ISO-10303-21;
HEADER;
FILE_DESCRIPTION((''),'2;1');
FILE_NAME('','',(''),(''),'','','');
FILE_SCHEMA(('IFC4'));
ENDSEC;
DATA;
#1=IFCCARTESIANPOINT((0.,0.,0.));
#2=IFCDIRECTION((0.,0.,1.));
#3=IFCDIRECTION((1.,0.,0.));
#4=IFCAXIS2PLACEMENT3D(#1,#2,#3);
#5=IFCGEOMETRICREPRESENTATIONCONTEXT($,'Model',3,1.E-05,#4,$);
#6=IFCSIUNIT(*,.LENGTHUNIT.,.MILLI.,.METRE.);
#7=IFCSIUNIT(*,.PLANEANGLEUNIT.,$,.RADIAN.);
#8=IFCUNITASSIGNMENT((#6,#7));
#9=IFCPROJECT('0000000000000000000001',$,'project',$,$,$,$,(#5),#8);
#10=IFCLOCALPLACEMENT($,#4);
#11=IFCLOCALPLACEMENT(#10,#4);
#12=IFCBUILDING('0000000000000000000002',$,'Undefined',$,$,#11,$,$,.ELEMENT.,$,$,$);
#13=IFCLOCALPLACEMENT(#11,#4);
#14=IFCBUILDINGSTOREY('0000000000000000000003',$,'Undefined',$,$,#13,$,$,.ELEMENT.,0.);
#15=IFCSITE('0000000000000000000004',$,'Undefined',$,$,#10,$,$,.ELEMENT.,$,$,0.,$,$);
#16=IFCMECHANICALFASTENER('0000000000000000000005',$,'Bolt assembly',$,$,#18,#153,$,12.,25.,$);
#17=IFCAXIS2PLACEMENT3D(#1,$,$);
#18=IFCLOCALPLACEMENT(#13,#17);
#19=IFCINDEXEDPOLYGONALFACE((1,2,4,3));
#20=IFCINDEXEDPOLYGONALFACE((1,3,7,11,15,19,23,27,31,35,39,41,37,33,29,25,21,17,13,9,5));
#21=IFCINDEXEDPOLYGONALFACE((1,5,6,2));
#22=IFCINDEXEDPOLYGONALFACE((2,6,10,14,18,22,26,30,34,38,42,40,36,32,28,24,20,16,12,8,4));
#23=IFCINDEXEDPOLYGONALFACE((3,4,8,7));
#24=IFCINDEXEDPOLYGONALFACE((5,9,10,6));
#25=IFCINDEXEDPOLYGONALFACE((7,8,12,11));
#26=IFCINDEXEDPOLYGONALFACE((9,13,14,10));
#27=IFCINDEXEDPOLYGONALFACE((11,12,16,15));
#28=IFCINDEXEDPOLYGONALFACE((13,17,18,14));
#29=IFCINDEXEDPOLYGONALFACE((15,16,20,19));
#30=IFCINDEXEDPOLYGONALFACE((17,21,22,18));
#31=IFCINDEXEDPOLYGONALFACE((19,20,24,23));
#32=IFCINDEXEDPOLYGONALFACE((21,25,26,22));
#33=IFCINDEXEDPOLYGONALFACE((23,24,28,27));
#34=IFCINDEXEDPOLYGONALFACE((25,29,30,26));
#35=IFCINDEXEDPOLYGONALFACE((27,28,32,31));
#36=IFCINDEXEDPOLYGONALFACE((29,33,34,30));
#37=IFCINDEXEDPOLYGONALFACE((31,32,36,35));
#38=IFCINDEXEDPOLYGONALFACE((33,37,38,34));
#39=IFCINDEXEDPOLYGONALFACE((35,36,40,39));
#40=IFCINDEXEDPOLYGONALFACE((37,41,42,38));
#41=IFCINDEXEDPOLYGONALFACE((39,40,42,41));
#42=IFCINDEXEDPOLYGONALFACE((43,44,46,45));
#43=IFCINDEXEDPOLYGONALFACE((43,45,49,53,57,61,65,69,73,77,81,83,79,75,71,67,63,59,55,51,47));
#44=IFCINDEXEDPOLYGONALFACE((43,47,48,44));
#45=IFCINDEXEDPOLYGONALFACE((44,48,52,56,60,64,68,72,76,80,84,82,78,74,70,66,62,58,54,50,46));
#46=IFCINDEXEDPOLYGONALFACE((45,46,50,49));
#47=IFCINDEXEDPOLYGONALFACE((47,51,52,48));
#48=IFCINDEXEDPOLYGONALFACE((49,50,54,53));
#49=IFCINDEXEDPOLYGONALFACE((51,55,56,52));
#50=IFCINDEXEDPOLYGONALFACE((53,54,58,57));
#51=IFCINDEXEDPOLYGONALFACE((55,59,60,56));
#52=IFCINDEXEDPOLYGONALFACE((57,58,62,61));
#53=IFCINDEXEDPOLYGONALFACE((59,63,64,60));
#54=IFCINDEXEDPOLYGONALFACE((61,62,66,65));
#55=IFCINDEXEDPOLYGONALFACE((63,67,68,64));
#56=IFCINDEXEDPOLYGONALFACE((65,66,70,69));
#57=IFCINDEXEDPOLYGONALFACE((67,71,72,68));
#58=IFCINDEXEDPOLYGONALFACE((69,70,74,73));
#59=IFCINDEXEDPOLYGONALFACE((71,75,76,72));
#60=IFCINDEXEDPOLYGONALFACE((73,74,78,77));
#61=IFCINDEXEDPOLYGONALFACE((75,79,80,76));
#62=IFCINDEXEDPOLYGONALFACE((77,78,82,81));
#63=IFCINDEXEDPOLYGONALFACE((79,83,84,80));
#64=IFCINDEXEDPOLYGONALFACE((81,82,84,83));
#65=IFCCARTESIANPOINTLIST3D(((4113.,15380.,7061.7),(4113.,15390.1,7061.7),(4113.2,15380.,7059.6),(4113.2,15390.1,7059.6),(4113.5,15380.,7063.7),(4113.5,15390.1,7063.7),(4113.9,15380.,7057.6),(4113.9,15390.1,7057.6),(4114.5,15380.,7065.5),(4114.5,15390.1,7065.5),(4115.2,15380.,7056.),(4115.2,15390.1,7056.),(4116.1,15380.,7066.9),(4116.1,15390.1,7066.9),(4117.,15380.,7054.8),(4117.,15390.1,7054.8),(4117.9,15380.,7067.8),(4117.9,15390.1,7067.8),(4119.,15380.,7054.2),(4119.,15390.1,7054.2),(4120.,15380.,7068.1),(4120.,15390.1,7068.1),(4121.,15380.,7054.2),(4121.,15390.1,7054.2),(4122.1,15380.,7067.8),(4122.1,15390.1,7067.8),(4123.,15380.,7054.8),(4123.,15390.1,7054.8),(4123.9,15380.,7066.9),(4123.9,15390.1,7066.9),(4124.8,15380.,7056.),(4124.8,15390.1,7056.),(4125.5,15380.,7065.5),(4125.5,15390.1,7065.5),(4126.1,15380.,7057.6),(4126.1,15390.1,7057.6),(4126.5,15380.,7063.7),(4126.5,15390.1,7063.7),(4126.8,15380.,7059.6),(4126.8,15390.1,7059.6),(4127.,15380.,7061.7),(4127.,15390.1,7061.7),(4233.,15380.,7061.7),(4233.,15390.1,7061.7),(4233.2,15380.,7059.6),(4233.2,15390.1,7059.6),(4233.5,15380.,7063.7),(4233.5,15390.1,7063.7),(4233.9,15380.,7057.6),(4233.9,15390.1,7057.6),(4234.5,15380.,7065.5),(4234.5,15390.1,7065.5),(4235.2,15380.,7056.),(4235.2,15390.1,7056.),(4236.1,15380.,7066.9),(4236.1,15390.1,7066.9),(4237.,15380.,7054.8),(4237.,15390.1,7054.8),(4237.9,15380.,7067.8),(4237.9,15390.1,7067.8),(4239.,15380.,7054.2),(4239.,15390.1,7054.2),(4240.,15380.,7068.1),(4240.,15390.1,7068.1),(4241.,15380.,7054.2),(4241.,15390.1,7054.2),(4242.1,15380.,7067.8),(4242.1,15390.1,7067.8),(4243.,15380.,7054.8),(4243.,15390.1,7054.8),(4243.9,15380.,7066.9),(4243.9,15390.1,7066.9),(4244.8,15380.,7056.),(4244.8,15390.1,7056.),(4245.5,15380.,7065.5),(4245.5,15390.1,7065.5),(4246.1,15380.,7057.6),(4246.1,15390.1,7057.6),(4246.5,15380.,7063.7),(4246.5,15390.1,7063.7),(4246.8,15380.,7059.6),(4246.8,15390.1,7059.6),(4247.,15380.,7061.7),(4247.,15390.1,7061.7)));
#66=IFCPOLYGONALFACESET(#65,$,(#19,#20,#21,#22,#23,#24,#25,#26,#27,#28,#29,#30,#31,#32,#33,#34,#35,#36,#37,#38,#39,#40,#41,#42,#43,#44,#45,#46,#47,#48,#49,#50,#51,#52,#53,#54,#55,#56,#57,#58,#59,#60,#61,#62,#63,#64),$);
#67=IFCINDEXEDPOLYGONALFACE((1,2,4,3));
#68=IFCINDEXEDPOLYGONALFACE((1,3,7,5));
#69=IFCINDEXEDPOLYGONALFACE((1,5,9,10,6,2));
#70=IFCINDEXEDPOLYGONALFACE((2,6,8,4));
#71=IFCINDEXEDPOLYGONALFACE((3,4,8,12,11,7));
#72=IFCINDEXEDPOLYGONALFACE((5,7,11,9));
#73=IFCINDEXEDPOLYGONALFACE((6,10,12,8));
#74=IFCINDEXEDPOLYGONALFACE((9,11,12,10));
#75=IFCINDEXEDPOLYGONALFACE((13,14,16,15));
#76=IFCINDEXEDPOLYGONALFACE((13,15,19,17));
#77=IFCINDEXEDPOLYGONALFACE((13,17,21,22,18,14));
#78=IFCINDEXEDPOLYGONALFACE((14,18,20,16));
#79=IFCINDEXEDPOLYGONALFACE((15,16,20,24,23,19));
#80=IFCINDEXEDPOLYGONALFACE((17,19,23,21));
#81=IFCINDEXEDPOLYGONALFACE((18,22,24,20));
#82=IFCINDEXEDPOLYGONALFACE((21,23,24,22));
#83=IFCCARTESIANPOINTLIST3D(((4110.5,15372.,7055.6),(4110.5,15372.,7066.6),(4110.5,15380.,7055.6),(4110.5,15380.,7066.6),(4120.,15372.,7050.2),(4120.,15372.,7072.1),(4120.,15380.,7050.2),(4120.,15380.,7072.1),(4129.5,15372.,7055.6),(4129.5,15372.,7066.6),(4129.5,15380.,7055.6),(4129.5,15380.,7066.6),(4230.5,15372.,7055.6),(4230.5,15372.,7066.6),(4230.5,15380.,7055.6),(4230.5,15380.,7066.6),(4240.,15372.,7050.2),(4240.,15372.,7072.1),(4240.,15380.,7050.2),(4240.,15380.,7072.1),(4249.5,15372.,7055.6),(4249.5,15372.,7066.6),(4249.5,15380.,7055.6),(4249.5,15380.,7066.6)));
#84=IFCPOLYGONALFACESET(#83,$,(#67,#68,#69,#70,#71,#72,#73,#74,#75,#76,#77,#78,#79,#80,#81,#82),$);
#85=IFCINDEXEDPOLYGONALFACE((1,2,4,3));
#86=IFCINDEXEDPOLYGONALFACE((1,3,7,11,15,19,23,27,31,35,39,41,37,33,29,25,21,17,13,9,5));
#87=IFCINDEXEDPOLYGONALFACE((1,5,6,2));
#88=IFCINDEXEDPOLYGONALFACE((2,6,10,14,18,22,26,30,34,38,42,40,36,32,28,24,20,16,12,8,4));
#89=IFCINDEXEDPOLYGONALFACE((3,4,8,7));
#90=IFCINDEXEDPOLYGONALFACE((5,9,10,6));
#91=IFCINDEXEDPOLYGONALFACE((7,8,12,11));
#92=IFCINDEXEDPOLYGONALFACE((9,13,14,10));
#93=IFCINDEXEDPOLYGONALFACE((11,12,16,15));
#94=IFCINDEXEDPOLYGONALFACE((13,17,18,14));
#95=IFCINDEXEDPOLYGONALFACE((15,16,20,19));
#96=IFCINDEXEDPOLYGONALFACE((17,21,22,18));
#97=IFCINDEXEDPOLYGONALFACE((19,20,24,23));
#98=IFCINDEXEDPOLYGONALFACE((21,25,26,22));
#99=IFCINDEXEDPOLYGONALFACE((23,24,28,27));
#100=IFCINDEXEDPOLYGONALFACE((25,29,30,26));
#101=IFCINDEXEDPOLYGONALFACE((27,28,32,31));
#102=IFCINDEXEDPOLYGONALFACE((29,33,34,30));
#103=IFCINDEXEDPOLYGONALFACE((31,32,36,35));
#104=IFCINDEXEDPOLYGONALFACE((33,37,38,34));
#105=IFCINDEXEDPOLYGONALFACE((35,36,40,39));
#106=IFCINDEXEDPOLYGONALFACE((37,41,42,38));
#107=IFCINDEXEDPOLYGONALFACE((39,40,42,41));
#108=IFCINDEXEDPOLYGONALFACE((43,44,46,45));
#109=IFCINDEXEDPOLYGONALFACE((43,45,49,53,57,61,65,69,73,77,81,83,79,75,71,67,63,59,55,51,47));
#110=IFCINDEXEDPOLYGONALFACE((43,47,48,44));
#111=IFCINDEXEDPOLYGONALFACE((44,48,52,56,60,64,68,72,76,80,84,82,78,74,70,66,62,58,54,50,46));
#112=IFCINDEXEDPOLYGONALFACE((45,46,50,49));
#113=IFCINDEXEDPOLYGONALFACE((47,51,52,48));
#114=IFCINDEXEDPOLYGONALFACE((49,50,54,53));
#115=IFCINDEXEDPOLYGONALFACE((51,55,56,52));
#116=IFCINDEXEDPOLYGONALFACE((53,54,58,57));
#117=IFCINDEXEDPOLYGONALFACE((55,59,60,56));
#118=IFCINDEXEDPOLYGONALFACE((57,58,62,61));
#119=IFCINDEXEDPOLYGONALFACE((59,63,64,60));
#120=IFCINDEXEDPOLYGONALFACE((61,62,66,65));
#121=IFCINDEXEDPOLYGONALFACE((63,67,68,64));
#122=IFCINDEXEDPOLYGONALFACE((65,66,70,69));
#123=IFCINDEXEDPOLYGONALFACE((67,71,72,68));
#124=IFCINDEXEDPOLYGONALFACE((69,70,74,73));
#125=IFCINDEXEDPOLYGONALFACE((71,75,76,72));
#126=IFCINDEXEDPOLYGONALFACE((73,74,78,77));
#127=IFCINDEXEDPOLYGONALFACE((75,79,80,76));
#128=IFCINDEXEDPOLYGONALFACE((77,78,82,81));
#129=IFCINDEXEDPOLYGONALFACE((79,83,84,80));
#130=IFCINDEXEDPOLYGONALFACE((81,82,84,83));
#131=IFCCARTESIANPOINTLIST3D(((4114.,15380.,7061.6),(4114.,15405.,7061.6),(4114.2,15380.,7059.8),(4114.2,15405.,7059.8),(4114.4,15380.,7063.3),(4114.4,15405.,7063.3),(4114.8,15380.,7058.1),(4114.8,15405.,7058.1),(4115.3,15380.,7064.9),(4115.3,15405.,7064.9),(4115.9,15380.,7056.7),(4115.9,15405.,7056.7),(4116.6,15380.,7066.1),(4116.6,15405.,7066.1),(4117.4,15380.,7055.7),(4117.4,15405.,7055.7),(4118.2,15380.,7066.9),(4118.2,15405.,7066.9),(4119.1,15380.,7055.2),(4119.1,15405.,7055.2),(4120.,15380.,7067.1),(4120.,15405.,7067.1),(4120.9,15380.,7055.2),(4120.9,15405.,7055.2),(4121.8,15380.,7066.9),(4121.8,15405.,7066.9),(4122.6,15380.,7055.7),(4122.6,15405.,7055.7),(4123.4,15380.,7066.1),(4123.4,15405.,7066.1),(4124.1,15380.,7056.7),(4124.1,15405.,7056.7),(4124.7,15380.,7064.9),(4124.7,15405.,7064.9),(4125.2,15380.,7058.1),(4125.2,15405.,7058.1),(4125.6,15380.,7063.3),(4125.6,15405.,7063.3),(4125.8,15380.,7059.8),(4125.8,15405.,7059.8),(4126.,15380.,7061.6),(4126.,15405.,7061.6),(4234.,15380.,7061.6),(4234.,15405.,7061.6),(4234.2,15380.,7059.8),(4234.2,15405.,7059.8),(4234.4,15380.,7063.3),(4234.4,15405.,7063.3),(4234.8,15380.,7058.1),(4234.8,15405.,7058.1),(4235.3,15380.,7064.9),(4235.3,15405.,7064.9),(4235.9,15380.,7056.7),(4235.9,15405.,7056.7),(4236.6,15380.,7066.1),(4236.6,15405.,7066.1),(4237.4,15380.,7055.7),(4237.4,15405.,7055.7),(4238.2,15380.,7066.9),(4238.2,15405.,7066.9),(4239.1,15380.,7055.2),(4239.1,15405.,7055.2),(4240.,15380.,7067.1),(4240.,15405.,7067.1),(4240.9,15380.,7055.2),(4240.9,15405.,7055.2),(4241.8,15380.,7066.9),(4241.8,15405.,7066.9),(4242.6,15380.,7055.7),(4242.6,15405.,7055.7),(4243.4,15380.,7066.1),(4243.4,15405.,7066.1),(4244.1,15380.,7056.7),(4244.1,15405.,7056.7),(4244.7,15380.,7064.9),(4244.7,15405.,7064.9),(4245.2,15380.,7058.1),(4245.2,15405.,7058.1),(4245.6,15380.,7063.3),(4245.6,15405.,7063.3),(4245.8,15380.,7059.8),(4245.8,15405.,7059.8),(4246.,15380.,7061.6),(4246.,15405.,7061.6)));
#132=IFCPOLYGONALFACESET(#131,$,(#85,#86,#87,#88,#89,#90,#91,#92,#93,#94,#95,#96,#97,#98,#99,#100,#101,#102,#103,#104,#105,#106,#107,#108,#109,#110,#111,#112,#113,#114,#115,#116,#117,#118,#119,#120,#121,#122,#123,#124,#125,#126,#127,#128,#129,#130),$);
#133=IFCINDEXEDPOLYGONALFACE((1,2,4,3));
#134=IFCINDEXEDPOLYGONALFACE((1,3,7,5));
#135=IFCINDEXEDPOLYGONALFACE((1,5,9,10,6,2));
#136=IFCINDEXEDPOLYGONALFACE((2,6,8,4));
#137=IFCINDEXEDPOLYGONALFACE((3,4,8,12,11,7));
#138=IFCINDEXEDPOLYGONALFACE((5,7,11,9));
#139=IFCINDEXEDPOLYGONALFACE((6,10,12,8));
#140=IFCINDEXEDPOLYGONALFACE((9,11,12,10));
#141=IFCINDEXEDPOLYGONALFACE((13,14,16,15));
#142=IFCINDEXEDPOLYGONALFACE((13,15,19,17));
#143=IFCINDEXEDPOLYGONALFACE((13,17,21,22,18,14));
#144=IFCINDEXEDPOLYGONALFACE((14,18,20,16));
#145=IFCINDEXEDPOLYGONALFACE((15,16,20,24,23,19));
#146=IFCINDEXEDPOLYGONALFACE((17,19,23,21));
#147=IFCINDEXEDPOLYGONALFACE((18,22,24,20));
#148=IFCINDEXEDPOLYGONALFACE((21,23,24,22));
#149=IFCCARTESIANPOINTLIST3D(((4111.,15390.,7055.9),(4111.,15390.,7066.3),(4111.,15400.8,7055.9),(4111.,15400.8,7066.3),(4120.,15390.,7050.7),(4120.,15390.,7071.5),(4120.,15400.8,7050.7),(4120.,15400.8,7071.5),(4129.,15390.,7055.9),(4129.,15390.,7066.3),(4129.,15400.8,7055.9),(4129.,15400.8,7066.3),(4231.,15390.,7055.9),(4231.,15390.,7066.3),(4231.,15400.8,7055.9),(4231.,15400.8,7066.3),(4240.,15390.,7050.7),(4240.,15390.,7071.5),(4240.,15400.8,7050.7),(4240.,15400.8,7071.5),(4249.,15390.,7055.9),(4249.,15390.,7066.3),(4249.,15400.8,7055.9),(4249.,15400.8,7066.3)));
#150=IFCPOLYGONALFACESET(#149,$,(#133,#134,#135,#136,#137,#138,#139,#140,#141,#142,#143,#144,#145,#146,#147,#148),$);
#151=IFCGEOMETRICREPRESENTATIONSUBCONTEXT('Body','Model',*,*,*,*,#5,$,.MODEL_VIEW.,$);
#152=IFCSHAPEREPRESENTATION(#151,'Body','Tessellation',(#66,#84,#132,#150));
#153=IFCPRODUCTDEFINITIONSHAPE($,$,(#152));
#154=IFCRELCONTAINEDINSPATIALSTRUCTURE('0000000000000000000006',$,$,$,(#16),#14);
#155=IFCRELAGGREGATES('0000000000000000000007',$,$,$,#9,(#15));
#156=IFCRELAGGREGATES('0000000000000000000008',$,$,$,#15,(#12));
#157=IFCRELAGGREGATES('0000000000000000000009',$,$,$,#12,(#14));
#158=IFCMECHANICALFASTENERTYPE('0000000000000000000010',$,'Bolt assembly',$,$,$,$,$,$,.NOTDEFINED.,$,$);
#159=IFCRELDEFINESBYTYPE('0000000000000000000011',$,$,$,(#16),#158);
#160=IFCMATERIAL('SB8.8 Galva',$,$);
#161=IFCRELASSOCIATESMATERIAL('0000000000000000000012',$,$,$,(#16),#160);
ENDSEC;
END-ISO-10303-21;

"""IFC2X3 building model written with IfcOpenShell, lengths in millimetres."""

from ifc_helpers import new_model, si_unit, frame, origin_with_axes, origin_2d_with_axis, place, context, subcontext, project, spatial, polyline, circle, outline, extrude, source, transform, mapped, material, type_object, element, save


model = new_model("IFC2X3")

# Units and contexts
model_context = context("Model", 3, precision=1e-05, world=origin_with_axes())
body_context = subcontext(model_context, "Body", "Model", "MODEL_VIEW")
ifc_project = project(units=[si_unit("LENGTHUNIT", "METRE", prefix="MILLI"), si_unit("PLANEANGLEUNIT", "RADIAN")], contexts=[model_context])

# Site, building, storey
site_placement = place(None, origin_with_axes())
site = spatial("IfcSite", under=ifc_project, at=site_placement, Name="Undefined", CompositionType="ELEMENT", RefElevation=0.0)
building_placement = place(site_placement, origin_with_axes())
building = spatial("IfcBuilding", under=site, at=building_placement, Name="Undefined", CompositionType="ELEMENT")
storey_placement = place(building_placement, origin_with_axes())
storey = spatial("IfcBuildingStorey", under=building, at=storey_placement, Name="Undefined", CompositionType="ELEMENT", Elevation=0.0)

# Mechanical fastener
mechanical_fastener_type = type_object("IfcMechanicalFastenerType", Name="Bolt assembly")
ifc_material_1 = material(Name="SB8.8 Galva")
shared_shape_1 = source(origin_with_axes(), body_context, "Body", "SweptSolid", [
    extrude(circle(Radius=7.0, at=origin_2d_with_axis()), frame((0.0, -10.0, 0.0), z_axis=(0.0, 1.0, 0.0), x_axis=(1.0, 0.0, 0.0)), (0.0, 0.0, 1.0), 10.1),
    extrude(outline(polyline([(11.0, 0.0), (5.5, 9.5), (-5.5, 9.5), (-11.0, 0.0), (-5.5, -9.5), (5.5, -9.5), (11.0, 0.0)])), frame((0.0, -18.0, 0.0), z_axis=(0.0, 1.0, 0.0), x_axis=(1.0, 0.0, 0.0)), (0.0, 0.0, 1.0), 8.0),
    extrude(circle(Radius=6.0, at=origin_2d_with_axis()), frame((0.0, -10.0, 0.0), z_axis=(0.0, 1.0, 0.0), x_axis=(1.0, 0.0, 0.0)), (0.0, 0.0, 1.0), 25.0),
    extrude(outline(polyline([(10.4, 0.0), (5.2, 9.0), (-5.2, 9.0), (-10.4, 0.0), (-5.2, -9.0), (5.2, -9.0), (10.4, 0.0)])), frame((0.0, 0.0, 0.0), z_axis=(0.0, 1.0, 0.0), x_axis=(1.0, 0.0, 0.0)), (0.0, 0.0, 1.0), 10.8),
])
mechanical_fastener_1_placement = place(storey_placement, frame((4180.0, 15390.0, 7061.1), z_axis=(-1.0, 0.0, 0.0), x_axis=(0.0, 0.0, 1.0)))
element("IfcMechanicalFastener", 1, at=mechanical_fastener_1_placement, inside=storey, type_object=mechanical_fastener_type, material=ifc_material_1, Name="Bolt assembly", NominalDiameter=12.0, NominalLength=25.0, context=body_context, shape_type="MappedRepresentation", body=[
    mapped(shared_shape_1, transform((0.0, 0.0, -60.0))),
    mapped(shared_shape_1, transform((0.0, 0.0, 60.0))),
])

save(model, "model.ifc")
